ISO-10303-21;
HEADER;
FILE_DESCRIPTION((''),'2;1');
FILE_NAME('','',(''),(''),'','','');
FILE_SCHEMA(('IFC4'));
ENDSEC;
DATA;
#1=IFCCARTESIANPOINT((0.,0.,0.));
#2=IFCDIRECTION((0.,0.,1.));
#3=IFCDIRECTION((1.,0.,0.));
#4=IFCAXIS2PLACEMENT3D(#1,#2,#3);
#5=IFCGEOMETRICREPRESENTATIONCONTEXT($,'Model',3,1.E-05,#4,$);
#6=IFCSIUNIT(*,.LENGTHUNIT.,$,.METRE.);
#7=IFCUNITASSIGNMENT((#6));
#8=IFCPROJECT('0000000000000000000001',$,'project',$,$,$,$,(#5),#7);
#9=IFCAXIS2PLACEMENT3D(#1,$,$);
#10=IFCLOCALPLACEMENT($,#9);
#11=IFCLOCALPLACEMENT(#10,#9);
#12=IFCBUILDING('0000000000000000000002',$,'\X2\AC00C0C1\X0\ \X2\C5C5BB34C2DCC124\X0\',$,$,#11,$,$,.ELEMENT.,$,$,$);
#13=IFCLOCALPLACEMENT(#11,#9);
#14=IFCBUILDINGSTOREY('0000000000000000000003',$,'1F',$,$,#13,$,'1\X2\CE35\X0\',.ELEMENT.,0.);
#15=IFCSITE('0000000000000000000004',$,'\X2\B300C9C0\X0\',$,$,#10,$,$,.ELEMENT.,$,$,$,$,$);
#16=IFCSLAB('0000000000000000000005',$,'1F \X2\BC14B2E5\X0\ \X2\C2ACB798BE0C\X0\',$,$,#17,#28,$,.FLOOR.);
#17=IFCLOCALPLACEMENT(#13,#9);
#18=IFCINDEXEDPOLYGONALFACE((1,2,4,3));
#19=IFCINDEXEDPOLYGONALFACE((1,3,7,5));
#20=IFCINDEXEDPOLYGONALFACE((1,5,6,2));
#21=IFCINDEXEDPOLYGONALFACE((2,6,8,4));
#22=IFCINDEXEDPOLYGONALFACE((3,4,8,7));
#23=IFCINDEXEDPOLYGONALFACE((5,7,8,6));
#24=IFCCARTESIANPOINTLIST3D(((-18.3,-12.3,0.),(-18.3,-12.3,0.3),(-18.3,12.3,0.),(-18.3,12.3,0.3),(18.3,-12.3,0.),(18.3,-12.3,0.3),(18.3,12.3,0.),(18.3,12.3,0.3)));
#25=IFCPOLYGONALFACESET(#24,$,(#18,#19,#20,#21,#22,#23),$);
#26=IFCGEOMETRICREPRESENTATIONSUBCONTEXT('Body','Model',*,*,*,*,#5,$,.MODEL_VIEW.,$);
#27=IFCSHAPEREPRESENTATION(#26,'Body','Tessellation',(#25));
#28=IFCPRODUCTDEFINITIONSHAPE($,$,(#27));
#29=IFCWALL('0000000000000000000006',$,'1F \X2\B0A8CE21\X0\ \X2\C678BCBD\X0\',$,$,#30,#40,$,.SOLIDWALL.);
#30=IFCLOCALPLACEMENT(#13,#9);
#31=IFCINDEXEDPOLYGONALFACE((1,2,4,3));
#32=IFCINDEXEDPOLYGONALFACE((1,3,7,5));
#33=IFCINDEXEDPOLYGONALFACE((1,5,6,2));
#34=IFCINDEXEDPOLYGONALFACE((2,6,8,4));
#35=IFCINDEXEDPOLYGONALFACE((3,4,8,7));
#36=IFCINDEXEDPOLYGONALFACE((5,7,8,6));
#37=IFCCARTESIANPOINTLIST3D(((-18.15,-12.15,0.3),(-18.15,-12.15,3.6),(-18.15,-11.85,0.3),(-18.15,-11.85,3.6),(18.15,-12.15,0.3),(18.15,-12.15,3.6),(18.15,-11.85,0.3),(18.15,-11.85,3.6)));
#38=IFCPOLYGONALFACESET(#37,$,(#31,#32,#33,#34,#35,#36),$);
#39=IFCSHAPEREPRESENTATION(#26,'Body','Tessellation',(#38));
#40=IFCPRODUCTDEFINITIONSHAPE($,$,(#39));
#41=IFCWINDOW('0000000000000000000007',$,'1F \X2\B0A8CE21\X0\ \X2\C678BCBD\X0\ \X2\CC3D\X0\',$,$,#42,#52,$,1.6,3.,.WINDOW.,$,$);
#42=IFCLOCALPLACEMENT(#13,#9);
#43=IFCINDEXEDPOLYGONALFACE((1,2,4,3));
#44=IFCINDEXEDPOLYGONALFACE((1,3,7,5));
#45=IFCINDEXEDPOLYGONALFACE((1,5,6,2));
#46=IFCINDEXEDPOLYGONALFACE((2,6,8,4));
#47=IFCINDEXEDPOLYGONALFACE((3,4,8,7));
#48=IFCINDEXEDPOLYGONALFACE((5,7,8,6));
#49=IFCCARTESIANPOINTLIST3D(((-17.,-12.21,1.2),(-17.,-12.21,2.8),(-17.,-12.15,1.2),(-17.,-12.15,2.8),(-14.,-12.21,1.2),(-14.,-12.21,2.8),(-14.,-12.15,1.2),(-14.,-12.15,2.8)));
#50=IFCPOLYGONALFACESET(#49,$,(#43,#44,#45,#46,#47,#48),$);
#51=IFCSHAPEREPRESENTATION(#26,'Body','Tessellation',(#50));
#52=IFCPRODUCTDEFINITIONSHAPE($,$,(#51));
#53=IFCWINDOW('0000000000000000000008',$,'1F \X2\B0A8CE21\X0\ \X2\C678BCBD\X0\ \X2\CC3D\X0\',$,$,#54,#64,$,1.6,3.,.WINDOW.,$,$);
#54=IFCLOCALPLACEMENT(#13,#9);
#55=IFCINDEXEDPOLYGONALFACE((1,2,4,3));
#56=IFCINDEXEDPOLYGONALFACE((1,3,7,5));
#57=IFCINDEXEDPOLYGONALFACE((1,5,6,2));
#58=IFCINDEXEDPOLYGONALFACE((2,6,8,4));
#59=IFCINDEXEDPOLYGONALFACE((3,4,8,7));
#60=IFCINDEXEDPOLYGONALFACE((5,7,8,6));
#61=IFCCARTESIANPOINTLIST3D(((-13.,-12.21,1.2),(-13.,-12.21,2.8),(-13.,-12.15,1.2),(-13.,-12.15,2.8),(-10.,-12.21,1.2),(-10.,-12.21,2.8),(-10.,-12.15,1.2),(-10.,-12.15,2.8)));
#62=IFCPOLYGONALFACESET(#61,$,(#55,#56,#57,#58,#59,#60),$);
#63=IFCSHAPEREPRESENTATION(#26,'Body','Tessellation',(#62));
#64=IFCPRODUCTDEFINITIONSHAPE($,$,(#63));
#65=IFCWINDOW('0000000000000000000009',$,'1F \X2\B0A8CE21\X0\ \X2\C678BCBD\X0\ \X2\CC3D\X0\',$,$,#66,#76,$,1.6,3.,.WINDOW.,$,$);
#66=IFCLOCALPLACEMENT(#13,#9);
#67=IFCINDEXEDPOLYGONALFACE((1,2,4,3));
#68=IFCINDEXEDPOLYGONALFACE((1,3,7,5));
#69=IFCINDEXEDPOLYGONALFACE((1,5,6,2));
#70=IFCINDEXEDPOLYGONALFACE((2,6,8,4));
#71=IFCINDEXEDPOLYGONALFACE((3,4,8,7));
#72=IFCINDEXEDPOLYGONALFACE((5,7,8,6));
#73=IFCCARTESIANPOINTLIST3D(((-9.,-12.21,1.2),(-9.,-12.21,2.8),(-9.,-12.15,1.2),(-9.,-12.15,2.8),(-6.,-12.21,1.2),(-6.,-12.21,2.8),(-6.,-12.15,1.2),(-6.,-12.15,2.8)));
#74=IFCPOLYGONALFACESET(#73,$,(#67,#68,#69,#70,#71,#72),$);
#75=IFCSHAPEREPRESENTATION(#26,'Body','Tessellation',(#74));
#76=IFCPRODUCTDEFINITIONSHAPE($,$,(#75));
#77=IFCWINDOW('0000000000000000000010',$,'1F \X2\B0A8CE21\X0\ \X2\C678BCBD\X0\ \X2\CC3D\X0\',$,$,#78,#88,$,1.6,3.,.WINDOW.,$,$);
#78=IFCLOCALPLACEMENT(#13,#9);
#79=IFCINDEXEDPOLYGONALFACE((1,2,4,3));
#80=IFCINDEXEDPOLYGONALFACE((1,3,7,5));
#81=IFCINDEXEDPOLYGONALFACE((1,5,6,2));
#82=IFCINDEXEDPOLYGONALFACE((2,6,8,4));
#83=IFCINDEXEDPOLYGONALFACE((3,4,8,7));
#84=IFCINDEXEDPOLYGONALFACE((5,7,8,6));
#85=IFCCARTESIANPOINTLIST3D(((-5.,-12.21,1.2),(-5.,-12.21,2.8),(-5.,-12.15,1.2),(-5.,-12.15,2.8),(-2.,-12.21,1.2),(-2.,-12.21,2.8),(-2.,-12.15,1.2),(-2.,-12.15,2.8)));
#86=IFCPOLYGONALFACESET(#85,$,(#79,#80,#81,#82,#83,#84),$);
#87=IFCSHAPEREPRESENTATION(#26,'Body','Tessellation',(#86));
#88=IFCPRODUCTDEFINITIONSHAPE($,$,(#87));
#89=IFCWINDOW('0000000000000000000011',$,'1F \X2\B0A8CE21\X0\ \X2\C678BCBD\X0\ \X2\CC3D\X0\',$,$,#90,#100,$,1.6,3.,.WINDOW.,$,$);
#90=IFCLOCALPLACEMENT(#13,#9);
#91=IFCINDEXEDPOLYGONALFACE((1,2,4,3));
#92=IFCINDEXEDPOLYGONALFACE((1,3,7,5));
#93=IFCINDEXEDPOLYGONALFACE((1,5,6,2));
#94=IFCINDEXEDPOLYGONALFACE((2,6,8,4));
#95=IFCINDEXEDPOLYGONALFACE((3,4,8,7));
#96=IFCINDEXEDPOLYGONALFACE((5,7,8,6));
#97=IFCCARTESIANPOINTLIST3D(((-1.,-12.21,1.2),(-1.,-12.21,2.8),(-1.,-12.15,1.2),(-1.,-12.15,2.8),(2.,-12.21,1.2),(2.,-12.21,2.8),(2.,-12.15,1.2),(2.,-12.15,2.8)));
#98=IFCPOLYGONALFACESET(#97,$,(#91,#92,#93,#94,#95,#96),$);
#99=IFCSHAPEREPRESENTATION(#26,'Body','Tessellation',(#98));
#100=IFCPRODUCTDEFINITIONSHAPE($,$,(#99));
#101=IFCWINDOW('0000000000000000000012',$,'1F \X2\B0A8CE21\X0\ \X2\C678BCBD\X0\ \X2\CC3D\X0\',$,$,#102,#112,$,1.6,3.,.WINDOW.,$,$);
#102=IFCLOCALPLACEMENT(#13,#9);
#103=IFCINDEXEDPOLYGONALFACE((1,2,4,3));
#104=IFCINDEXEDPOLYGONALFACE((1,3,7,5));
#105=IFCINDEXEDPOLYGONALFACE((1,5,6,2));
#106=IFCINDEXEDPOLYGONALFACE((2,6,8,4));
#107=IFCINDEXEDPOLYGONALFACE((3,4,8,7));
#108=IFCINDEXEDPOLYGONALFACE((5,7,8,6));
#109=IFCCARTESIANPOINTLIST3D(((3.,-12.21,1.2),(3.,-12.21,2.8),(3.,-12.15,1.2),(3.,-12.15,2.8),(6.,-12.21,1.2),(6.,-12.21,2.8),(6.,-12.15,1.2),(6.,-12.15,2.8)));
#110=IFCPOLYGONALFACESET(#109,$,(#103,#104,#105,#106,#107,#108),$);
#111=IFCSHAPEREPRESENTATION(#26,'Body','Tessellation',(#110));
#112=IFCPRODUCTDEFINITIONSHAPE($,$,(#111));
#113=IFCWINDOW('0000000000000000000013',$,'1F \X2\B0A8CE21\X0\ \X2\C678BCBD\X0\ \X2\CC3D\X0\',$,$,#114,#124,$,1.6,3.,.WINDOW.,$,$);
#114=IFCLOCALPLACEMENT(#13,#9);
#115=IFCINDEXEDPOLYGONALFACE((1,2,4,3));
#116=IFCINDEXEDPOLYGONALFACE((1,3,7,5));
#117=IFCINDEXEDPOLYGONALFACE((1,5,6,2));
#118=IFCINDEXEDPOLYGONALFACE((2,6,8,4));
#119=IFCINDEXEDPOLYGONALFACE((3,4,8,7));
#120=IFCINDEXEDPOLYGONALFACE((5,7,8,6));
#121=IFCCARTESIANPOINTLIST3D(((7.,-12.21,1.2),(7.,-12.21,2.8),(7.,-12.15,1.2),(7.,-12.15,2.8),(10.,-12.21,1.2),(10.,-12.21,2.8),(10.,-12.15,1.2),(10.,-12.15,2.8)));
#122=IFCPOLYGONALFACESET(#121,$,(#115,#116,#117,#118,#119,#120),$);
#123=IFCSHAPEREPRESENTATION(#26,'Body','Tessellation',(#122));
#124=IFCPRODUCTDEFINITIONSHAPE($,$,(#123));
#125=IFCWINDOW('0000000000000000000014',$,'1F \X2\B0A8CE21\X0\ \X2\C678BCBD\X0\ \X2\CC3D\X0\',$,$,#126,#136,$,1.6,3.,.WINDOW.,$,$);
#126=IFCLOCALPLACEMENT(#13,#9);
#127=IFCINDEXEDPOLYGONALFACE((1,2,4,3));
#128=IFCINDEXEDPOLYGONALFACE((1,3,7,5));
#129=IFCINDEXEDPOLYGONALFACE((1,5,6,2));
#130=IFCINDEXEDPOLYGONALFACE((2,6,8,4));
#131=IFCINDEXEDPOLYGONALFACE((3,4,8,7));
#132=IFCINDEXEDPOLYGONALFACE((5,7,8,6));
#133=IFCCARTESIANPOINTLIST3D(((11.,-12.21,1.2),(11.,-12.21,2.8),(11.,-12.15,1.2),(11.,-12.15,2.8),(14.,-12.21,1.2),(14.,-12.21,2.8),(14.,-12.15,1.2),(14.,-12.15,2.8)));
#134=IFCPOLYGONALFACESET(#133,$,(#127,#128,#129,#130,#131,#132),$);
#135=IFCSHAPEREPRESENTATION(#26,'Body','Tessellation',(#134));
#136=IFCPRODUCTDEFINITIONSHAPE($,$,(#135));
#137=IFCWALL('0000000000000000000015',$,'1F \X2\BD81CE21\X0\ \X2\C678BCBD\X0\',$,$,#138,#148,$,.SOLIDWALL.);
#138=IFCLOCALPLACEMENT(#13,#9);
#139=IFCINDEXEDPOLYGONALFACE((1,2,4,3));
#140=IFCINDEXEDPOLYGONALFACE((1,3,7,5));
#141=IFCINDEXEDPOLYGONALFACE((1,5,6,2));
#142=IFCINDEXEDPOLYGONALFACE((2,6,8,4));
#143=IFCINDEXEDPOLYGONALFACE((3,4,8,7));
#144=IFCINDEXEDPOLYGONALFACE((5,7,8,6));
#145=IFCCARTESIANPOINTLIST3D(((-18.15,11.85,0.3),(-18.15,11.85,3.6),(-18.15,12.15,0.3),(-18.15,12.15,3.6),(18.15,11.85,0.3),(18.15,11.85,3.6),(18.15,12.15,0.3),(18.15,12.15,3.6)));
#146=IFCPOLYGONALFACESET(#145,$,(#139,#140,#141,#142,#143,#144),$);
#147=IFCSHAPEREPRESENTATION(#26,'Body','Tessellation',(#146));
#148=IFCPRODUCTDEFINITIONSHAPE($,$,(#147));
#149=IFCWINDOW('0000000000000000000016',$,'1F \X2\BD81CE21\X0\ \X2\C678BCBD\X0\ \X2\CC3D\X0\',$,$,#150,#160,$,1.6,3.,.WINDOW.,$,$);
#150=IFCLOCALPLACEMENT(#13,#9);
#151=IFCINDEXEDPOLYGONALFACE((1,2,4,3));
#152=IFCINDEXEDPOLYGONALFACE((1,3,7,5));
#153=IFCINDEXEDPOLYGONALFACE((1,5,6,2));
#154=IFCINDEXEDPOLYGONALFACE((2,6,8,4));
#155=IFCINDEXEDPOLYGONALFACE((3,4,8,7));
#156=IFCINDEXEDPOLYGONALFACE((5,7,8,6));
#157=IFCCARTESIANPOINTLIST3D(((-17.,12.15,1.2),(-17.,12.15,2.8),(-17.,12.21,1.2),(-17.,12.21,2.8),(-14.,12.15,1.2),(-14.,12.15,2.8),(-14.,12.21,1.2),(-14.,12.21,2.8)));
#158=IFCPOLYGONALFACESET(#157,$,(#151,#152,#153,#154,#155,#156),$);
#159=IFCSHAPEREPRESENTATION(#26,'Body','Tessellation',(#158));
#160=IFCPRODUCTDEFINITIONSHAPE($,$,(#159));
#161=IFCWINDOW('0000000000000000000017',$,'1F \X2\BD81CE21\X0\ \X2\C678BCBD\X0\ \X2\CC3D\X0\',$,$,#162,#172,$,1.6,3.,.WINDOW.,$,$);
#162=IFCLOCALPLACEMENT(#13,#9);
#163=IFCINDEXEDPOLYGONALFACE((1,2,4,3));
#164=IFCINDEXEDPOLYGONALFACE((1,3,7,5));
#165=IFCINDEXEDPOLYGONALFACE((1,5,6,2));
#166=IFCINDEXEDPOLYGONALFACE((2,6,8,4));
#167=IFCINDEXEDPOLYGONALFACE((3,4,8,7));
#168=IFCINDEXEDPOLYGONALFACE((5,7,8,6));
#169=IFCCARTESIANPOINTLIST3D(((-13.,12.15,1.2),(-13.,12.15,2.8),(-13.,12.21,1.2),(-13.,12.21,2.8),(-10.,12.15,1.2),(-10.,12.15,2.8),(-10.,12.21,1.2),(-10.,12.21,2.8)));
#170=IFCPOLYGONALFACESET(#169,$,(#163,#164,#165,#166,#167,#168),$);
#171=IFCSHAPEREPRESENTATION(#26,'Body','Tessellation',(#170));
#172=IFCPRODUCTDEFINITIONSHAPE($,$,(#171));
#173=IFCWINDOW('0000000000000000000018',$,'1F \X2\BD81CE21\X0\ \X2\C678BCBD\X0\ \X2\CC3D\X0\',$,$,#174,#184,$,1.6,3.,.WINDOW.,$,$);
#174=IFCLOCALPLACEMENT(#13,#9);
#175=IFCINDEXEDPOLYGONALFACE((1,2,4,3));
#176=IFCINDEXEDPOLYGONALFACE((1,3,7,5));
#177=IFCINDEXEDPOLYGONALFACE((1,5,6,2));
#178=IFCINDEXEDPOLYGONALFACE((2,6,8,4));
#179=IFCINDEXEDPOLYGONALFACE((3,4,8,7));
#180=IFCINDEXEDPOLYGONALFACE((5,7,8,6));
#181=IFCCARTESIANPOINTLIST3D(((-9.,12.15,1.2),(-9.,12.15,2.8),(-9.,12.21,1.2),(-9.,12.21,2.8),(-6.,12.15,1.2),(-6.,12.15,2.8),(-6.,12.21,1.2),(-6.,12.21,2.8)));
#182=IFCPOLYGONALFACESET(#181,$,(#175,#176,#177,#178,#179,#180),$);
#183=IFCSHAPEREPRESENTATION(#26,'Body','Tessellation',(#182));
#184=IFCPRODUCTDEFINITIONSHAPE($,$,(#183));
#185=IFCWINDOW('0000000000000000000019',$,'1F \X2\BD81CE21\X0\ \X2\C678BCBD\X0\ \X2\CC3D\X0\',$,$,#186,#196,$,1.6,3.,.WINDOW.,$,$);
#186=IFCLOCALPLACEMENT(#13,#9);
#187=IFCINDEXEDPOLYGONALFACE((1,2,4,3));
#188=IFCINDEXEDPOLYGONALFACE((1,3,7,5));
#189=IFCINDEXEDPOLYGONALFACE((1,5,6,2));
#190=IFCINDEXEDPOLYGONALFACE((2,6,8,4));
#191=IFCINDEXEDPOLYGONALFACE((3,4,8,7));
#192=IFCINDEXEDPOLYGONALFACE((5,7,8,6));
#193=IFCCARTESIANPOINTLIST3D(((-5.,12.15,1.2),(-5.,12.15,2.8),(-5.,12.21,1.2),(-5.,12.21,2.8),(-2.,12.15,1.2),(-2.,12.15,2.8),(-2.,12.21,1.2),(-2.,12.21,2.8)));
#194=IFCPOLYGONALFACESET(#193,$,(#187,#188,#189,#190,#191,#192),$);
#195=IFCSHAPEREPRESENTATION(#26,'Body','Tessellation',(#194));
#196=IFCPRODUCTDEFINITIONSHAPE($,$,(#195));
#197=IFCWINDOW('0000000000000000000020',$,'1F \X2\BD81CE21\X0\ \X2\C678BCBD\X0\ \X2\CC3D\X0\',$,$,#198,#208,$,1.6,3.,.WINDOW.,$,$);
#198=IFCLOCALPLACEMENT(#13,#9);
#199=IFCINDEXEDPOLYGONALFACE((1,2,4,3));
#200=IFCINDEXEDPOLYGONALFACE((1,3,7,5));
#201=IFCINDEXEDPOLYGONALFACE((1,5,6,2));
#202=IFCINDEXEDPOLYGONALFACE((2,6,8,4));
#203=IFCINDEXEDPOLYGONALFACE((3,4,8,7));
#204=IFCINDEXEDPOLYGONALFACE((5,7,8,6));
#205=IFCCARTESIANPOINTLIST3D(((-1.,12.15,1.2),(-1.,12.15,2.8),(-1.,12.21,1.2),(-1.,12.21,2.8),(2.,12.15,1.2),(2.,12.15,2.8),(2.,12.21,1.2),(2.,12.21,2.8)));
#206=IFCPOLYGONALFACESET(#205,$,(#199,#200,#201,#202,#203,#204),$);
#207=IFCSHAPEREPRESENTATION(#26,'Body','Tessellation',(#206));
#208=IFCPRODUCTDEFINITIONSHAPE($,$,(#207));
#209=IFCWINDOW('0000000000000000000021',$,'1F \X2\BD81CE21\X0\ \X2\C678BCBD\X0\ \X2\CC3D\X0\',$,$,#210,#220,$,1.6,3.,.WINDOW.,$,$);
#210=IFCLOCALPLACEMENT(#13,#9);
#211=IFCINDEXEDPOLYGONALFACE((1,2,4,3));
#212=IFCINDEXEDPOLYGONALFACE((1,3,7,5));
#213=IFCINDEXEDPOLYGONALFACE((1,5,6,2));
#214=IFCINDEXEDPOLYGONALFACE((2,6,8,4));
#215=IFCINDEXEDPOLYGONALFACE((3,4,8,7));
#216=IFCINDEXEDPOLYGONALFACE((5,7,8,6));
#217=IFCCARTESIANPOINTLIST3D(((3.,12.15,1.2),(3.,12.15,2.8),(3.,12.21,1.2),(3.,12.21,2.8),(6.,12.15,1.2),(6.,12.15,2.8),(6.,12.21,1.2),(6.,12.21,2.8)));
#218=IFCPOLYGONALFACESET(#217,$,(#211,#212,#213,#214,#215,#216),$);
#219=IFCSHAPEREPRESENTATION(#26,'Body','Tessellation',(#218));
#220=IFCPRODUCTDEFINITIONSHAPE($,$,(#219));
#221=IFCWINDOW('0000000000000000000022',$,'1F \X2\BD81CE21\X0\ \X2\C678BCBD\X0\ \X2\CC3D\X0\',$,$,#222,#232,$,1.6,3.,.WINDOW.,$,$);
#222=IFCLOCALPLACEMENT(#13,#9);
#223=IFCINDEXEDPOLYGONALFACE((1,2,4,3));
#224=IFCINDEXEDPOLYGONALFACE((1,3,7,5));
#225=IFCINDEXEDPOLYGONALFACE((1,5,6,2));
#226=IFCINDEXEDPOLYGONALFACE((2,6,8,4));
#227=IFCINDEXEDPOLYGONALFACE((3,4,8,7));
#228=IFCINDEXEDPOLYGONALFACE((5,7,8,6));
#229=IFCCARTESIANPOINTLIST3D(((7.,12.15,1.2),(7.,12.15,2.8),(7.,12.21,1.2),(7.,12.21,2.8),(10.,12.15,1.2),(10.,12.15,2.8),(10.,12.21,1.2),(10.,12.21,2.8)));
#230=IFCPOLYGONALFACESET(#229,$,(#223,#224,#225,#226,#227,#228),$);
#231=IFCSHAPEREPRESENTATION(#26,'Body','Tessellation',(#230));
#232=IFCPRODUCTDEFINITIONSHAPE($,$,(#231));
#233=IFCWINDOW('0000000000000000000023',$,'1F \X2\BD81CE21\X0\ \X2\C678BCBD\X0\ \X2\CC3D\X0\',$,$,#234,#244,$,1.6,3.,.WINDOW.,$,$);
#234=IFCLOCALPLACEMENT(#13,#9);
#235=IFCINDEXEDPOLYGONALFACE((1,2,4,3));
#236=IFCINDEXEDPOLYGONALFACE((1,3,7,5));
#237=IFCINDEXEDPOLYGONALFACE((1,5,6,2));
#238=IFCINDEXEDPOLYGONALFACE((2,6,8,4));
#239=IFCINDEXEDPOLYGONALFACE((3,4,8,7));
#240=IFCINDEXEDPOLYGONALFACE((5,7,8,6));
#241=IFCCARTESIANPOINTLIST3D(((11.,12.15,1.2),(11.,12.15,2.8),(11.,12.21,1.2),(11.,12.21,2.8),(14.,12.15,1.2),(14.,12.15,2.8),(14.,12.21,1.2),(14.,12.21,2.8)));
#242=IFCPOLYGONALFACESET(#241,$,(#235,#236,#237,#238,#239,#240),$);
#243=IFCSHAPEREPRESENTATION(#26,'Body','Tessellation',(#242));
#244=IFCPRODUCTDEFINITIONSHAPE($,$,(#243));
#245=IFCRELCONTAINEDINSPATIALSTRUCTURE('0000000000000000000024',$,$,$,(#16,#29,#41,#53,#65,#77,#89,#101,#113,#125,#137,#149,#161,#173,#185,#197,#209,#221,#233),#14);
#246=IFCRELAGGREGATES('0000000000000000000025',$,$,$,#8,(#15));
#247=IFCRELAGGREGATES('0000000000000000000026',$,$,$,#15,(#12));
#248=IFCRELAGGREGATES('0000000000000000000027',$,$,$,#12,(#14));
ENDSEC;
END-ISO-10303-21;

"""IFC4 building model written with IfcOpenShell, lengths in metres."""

from ifc_helpers import new_model, si_unit, frame, origin, origin_with_axes, origin_2d, place, context, subcontext, project, spatial, rectangle, extrude, element, save


model = new_model("IFC4")

# Units and contexts
model_context = context("Model", 3, precision=1e-05, world=origin_with_axes())
body_context = subcontext(model_context, "Body", "Model", "MODEL_VIEW")
ifc_project = project(units=[si_unit("LENGTHUNIT", "METRE")], contexts=[model_context])

# Site, building, storey
site_placement = place(None, origin())
site = spatial("IfcSite", under=ifc_project, at=site_placement, Name="대지", CompositionType="ELEMENT")
building_placement = place(site_placement, origin())
building = spatial("IfcBuilding", under=site, at=building_placement, Name="가상 업무시설", CompositionType="ELEMENT")
storey_placement = place(building_placement, origin())
storey = spatial("IfcBuildingStorey", under=building, at=storey_placement, Name="1F", LongName="1층", CompositionType="ELEMENT", Elevation=0.0)

# Slab
slab_placement = place(storey_placement, origin())
element("IfcSlab", 1, at=slab_placement, inside=storey, Name="1F 바닥 슬래브", PredefinedType="FLOOR", context=body_context, shape_type="SweptSolid", body=[
    extrude(rectangle(XDim=36.6, YDim=24.6, at=origin_2d()), origin_with_axes(), (0.0, 0.0, 1.0), 0.3),
])

# Wall
wall_1_placement = place(storey_placement, frame((0.0, -12.0, 0.3)))
element("IfcWall", 2, at=wall_1_placement, inside=storey, Name="1F 남측 외벽", PredefinedType="SOLIDWALL", context=body_context, shape_type="SweptSolid", body=[
    extrude(rectangle(XDim=36.3, YDim=0.3, at=origin_2d()), origin_with_axes(), (0.0, 0.0, 1.0), 3.3),
])

# Windows
for number, where, name in (
    (3, (-15.5, -12.18, 1.2), "1F 남측 외벽 창"),
    (4, (-11.5, -12.18, 1.2), "1F 남측 외벽 창"),
    (5, (-7.5, -12.18, 1.2), "1F 남측 외벽 창"),
    (6, (-3.5, -12.18, 1.2), "1F 남측 외벽 창"),
    (7, (0.5, -12.18, 1.2), "1F 남측 외벽 창"),
    (8, (4.5, -12.18, 1.2), "1F 남측 외벽 창"),
    (9, (8.5, -12.18, 1.2), "1F 남측 외벽 창"),
    (10, (12.5, -12.18, 1.2), "1F 남측 외벽 창"),
):
    element("IfcWindow", number, at=place(storey_placement, frame(where)), inside=storey, Name=name, OverallHeight=1.6, OverallWidth=3.0, PredefinedType="WINDOW", context=body_context, shape_type="SweptSolid", body=[
        extrude(rectangle(XDim=3.0, YDim=0.06, at=origin_2d()), origin_with_axes(), (0.0, 0.0, 1.0), 1.6),
    ])

# Wall
wall_2_placement = place(storey_placement, frame((0.0, 12.0, 0.3)))
element("IfcWall", 11, at=wall_2_placement, inside=storey, Name="1F 북측 외벽", PredefinedType="SOLIDWALL", context=body_context, shape_type="SweptSolid", body=[
    extrude(rectangle(XDim=36.3, YDim=0.3, at=origin_2d()), origin_with_axes(), (0.0, 0.0, 1.0), 3.3),
])

# Windows
for number, where, name in (
    (12, (-15.5, 12.18, 1.2), "1F 북측 외벽 창"),
    (13, (-11.5, 12.18, 1.2), "1F 북측 외벽 창"),
    (14, (-7.5, 12.18, 1.2), "1F 북측 외벽 창"),
    (15, (-3.5, 12.18, 1.2), "1F 북측 외벽 창"),
    (16, (0.5, 12.18, 1.2), "1F 북측 외벽 창"),
    (17, (4.5, 12.18, 1.2), "1F 북측 외벽 창"),
    (18, (8.5, 12.18, 1.2), "1F 북측 외벽 창"),
    (19, (12.5, 12.18, 1.2), "1F 북측 외벽 창"),
):
    element("IfcWindow", number, at=place(storey_placement, frame(where)), inside=storey, Name=name, OverallHeight=1.6, OverallWidth=3.0, PredefinedType="WINDOW", context=body_context, shape_type="SweptSolid", body=[
        extrude(rectangle(XDim=3.0, YDim=0.06, at=origin_2d()), origin_with_axes(), (0.0, 0.0, 1.0), 1.6),
    ])

save(model, "model.ifc")
